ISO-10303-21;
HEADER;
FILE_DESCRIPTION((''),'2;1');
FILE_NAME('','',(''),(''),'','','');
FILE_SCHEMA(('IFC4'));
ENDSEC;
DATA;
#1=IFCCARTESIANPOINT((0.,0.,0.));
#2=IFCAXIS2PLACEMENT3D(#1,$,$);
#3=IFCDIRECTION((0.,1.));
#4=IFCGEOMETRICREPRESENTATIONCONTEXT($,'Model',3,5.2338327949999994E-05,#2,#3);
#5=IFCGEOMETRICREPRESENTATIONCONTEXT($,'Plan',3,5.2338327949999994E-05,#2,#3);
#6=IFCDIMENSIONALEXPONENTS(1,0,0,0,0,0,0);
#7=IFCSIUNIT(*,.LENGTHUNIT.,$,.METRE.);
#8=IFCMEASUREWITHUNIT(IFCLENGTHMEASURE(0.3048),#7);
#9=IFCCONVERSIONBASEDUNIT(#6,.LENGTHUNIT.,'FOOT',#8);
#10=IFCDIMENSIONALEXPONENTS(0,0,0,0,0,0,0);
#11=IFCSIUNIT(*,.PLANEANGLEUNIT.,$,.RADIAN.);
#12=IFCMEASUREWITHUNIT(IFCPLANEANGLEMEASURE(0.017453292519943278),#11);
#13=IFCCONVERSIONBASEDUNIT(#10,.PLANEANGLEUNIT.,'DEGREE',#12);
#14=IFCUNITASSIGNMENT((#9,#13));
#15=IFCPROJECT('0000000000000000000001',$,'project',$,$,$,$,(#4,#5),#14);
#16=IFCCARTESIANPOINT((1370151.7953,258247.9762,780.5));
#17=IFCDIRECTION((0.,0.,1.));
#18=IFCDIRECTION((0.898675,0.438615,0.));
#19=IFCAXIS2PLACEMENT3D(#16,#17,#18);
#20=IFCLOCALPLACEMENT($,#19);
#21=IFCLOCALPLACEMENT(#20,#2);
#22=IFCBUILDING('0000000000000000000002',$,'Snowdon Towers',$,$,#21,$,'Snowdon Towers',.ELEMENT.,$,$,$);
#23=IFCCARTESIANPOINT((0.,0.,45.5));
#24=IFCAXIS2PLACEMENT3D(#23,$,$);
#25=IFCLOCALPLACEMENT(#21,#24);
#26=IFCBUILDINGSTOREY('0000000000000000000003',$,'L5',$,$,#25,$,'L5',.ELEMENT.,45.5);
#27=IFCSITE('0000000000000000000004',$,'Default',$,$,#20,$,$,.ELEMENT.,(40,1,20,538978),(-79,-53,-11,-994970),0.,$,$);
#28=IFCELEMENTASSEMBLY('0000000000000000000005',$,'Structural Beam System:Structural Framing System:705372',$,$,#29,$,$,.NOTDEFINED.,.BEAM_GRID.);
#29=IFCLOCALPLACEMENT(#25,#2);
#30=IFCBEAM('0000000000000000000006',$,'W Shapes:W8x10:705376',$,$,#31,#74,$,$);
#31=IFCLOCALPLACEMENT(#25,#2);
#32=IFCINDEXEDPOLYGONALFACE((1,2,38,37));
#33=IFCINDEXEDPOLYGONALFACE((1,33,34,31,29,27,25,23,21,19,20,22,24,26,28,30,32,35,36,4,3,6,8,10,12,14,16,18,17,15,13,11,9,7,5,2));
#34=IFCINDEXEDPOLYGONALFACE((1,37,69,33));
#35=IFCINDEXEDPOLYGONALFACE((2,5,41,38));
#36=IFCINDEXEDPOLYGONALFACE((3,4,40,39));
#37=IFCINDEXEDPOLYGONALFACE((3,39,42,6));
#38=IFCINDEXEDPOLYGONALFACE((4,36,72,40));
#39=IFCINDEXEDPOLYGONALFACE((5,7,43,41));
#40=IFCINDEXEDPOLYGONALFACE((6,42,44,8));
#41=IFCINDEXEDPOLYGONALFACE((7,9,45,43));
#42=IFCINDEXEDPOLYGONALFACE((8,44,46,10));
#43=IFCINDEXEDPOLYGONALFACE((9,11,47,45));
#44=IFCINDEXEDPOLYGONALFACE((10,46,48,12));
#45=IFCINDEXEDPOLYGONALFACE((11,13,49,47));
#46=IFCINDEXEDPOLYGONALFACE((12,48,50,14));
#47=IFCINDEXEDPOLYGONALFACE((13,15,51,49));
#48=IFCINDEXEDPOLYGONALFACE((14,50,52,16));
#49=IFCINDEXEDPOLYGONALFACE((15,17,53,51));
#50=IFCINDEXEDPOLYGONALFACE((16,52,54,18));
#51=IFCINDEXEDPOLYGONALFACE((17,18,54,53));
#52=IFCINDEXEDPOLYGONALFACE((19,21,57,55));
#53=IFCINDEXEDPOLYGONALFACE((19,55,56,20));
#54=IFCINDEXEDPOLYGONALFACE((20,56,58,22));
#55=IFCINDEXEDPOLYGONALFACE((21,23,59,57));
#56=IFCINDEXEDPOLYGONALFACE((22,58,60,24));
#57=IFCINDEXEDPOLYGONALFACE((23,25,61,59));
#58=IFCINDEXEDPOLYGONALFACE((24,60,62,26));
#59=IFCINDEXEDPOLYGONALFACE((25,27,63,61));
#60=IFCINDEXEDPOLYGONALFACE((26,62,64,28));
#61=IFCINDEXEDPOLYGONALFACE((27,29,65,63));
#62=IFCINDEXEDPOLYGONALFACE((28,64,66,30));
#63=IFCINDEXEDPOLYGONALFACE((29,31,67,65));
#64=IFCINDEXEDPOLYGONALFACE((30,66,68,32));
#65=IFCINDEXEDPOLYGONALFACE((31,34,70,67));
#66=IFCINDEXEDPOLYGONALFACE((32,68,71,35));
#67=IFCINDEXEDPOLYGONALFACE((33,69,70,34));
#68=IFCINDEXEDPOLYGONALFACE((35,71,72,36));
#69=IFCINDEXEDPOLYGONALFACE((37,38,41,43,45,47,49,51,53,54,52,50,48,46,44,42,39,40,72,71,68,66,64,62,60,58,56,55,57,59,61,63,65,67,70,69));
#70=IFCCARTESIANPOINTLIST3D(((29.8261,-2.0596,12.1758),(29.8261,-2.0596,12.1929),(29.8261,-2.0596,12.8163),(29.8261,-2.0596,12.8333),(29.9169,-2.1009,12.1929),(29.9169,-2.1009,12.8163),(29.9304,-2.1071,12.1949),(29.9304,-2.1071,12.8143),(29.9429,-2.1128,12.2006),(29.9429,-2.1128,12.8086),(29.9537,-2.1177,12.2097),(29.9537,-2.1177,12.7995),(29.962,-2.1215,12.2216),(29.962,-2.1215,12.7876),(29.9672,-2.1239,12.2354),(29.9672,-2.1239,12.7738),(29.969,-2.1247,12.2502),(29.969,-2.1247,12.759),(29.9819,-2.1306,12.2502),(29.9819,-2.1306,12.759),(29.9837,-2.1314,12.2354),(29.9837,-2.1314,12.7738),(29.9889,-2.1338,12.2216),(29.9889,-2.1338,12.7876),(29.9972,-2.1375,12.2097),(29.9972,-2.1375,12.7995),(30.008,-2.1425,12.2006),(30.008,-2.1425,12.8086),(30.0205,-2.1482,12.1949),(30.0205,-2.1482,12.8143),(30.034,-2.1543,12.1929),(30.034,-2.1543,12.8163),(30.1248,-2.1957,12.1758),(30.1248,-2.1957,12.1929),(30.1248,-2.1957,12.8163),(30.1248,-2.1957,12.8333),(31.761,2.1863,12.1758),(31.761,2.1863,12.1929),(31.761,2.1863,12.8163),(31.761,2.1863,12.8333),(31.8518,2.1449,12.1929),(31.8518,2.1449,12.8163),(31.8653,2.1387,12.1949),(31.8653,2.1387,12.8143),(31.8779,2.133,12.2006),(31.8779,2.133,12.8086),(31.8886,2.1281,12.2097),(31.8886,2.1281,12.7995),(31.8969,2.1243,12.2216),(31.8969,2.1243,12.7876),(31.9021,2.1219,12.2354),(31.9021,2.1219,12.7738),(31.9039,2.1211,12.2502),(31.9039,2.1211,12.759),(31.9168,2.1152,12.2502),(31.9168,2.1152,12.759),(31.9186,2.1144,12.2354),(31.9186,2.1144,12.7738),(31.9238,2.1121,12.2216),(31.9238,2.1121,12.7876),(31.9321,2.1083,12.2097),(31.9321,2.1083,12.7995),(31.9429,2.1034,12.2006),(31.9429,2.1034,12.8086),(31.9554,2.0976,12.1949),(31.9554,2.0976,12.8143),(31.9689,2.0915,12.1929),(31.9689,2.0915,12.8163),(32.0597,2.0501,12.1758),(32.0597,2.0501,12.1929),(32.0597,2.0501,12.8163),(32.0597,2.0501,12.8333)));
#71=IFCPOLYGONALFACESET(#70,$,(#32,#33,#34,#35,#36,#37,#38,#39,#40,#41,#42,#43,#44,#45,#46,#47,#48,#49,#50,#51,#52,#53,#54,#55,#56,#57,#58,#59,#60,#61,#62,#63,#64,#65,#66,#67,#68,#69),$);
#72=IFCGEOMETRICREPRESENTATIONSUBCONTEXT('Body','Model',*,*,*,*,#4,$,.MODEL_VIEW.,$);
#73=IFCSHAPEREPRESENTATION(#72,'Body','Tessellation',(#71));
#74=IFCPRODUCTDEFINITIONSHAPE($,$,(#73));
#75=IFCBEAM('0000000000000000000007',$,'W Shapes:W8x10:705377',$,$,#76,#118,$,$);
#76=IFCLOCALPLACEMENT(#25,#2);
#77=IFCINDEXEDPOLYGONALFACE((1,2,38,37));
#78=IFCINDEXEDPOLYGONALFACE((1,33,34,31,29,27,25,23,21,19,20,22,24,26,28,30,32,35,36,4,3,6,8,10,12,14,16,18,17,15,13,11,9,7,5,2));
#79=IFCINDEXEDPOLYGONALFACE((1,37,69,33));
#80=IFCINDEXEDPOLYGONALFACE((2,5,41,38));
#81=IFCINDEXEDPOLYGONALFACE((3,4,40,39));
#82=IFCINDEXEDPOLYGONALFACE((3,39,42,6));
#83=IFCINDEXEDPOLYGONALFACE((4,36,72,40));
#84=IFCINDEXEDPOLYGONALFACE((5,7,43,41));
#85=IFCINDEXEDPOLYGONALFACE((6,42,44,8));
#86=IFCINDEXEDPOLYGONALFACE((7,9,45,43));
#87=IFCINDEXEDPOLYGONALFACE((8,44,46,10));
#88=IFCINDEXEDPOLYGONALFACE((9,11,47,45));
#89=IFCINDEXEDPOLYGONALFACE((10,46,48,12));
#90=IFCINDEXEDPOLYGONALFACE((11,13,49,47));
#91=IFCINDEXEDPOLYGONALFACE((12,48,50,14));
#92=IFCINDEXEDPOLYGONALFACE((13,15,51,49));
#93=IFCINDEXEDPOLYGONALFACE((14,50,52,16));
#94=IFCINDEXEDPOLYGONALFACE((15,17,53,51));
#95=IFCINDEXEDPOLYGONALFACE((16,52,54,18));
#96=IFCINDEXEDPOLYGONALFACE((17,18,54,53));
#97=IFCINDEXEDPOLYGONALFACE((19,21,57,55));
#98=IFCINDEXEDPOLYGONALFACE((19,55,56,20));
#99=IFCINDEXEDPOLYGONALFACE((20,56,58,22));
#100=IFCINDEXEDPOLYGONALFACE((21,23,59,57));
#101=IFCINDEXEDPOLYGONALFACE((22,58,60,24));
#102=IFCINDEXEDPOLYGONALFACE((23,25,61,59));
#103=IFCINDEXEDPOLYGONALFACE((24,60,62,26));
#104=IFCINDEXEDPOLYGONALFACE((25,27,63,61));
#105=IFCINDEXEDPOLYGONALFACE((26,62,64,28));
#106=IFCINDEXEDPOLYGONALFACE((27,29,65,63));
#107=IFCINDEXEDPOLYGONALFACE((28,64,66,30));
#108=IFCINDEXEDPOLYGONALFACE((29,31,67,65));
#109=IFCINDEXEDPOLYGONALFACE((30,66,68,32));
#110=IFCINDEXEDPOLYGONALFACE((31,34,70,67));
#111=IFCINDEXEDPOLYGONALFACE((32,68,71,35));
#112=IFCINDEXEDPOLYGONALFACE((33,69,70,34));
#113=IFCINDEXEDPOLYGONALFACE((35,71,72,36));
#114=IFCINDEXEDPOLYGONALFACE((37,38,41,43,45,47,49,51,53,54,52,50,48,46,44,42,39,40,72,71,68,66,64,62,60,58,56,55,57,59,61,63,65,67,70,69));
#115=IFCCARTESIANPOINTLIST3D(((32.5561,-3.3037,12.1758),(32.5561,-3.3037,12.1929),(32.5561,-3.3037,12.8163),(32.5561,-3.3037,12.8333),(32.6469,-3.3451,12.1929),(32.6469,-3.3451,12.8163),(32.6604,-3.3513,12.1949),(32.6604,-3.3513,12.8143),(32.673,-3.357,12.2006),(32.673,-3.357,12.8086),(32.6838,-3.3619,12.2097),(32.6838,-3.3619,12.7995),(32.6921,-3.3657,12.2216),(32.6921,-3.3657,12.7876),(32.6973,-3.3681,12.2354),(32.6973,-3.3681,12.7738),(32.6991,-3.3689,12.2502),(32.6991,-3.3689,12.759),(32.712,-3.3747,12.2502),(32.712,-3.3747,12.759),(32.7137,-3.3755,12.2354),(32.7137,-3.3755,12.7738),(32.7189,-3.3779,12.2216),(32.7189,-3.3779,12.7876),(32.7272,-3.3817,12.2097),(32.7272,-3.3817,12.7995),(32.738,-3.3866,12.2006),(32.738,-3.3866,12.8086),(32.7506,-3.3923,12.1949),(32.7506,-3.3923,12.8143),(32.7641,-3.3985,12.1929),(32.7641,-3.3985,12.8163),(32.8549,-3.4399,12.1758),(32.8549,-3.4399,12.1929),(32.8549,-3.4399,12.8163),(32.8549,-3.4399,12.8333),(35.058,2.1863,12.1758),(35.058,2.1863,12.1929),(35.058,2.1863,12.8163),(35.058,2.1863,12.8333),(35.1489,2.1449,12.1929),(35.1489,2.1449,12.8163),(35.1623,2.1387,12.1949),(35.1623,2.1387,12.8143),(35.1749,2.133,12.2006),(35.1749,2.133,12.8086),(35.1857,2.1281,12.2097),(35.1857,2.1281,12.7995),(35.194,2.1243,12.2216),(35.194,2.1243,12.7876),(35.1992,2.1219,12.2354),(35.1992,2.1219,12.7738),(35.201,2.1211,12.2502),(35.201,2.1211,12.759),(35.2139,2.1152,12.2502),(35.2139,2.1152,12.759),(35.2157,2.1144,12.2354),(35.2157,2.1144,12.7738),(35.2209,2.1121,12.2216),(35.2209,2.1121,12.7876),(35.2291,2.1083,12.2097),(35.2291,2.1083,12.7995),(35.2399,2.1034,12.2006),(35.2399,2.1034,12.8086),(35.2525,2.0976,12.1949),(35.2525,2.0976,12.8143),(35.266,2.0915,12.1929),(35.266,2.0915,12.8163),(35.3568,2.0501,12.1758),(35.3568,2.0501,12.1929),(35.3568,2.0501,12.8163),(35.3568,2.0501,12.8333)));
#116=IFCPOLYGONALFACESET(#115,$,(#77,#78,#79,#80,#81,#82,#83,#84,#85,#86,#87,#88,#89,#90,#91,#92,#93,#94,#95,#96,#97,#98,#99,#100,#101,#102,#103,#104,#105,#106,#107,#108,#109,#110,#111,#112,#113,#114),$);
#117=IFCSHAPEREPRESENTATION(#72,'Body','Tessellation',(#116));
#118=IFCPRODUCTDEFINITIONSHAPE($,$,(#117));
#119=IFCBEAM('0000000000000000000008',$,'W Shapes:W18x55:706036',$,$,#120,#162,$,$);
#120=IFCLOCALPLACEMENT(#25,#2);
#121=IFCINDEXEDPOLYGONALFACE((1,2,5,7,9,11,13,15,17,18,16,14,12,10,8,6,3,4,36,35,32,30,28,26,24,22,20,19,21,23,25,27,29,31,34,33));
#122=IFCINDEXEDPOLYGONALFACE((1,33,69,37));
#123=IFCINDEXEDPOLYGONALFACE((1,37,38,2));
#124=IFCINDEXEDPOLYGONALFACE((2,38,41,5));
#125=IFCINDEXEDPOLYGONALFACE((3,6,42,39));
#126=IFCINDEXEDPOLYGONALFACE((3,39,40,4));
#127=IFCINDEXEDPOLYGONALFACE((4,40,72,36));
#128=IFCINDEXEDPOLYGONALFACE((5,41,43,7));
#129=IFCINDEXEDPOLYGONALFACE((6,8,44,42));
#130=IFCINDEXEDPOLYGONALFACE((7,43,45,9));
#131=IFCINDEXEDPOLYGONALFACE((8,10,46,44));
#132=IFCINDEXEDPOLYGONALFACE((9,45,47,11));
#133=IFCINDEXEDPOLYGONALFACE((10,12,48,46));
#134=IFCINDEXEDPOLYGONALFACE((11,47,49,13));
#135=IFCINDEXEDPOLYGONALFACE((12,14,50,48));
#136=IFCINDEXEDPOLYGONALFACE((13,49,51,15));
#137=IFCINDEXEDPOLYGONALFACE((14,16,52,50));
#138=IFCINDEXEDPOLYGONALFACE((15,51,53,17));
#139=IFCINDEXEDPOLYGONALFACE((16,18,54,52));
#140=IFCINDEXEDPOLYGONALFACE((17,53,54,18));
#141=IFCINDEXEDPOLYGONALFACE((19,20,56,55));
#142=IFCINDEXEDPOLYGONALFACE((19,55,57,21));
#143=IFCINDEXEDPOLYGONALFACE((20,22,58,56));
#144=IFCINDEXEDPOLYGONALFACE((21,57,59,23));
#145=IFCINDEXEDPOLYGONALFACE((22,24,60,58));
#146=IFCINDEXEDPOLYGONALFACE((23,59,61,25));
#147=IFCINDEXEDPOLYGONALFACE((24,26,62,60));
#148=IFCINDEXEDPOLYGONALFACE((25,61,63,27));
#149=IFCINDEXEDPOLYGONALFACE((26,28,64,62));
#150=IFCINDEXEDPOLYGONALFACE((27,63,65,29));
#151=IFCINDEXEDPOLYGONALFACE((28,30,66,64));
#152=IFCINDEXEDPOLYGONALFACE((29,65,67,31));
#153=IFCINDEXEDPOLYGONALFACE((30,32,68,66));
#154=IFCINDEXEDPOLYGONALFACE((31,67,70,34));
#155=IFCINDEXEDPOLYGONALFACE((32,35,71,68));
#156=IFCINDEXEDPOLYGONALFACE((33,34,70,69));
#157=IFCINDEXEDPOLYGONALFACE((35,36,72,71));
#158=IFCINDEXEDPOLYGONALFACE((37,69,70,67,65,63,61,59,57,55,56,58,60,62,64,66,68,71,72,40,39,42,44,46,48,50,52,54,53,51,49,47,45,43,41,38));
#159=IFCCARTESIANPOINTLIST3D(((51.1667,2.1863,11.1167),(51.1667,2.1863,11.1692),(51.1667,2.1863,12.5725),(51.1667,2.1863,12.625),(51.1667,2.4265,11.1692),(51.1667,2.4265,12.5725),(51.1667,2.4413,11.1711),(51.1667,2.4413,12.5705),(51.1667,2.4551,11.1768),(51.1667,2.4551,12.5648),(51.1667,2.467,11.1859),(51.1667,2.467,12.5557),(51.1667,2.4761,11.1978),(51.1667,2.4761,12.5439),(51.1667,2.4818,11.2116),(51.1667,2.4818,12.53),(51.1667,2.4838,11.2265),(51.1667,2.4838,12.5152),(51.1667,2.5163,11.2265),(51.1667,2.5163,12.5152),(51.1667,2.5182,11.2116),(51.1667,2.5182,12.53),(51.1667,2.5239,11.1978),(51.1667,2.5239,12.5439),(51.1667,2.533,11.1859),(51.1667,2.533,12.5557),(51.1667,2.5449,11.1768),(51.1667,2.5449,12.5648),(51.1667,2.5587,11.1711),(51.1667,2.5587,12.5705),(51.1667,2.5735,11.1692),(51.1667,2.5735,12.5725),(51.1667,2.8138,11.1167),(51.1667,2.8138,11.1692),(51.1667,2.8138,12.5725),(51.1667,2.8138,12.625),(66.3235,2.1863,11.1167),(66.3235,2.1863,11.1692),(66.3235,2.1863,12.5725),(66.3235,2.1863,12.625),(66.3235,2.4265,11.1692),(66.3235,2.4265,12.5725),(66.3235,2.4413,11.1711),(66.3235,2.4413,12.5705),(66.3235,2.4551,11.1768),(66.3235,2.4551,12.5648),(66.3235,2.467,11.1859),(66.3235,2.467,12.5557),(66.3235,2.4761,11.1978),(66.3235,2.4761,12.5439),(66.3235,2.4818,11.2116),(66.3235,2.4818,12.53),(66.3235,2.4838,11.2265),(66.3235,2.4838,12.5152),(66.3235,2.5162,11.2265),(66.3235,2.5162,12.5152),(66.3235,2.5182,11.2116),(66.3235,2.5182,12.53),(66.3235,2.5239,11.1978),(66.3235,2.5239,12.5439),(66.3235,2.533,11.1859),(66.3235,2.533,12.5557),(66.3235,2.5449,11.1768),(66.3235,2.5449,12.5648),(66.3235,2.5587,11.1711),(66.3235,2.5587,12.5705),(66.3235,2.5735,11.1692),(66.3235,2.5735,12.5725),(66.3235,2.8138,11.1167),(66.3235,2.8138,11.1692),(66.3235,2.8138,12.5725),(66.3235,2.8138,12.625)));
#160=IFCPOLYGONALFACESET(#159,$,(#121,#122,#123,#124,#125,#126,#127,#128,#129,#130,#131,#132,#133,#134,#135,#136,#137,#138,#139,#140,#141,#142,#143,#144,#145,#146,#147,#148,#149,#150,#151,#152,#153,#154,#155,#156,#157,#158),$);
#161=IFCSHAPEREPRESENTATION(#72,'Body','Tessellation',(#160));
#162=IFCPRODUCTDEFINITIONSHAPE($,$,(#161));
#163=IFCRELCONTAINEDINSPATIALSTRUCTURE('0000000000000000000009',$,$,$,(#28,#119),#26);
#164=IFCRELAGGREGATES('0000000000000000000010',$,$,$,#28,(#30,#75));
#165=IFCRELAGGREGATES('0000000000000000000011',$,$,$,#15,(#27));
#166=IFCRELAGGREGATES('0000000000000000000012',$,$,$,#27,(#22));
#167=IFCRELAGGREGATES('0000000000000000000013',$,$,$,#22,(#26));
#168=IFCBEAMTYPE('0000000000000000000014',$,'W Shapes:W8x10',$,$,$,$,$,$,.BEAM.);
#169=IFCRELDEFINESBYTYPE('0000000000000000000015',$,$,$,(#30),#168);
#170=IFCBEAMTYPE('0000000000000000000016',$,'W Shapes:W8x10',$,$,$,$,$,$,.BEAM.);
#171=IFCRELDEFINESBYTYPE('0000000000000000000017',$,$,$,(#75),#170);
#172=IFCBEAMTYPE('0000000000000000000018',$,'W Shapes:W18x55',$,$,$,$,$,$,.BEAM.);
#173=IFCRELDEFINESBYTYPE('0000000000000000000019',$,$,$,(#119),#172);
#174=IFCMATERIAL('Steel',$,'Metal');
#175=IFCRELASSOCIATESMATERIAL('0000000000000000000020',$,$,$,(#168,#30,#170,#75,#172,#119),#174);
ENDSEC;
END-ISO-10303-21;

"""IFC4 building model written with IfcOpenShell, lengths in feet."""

from ifc_helpers import new_model, entity, si_unit, converted_unit, direction, frame, origin, place, context, subcontext, project, spatial, line, arc, indexed_curve, outline, extrude, source, transform, mapped, material, type_object, type_shapes, element, aggregate, save


model = new_model("IFC4")

# Units and contexts
model_context = context("Model", 3, precision=5.2338327949999994e-05, world=origin(), true_north=direction((0.0, 1.0)))
plan_context = context("Plan", 3, precision=5.2338327949999994e-05, world=origin(), true_north=direction((0.0, 1.0)))
body_context = subcontext(model_context, "Body", "Model", "MODEL_VIEW")
ifc_project = project(units=[converted_unit("LENGTHUNIT", "FOOT", entity("IfcLengthMeasure", 0.3048), si_unit("LENGTHUNIT", "METRE"), dimensions=[1, 0, 0, 0, 0, 0, 0]), converted_unit("PLANEANGLEUNIT", "DEGREE", entity("IfcPlaneAngleMeasure", 0.017453292519943278), si_unit("PLANEANGLEUNIT", "RADIAN"), dimensions=[0, 0, 0, 0, 0, 0, 0])], contexts=[model_context, plan_context])

# Site, building, storey
site_placement = place(None, frame((1370151.7953, 258247.9762, 780.5), z_axis=(0.0, 0.0, 1.0), x_axis=(0.898675, 0.438615, 0.0)))
site = spatial("IfcSite", under=ifc_project, at=site_placement, Name="Default", CompositionType="ELEMENT", RefLatitude=(40, 1, 20, 538978), RefLongitude=(-79, -53, -11, -994970), RefElevation=0.0)
building_placement = place(site_placement, origin())
building = spatial("IfcBuilding", under=site, at=building_placement, Name="Snowdon Towers", LongName="Snowdon Towers", CompositionType="ELEMENT")
storey_placement = place(building_placement, frame((0.0, 0.0, 45.5)))
storey = spatial("IfcBuildingStorey", under=building, at=storey_placement, Name="L5", LongName="L5", CompositionType="ELEMENT", Elevation=45.5)

# Shared definitions
ifc_material = material(Name="Steel", Category="Metal")

# Element assembly, beams
assembly_1_placement = place(storey_placement, origin())
assembly_1 = element("IfcElementAssembly", 1, at=assembly_1_placement, inside=storey, Name="Structural Beam System:Structural Framing System:705372", AssemblyPlace="NOTDEFINED", PredefinedType="BEAM_GRID")
beam_type_1 = type_object("IfcBeamType", Name="W Shapes:W8x10", PredefinedType="BEAM", material=ifc_material)
shared_shape_1 = source(origin(), body_context, "Body", "SweptSolid", [
    extrude(outline(indexed_curve([(-0.3287, -0.1642), (-0.3117, -0.1642), (-0.3117, -0.0644), (-0.2949, -0.0239), (-0.2544, -0.0071), (0.2544, -0.0071), (0.2949, -0.0239), (0.3117, -0.0644), (0.3117, -0.1642), (0.3288, -0.1642), (0.3288, 0.1642), (0.3117, 0.1642), (0.3117, 0.0644), (0.2949, 0.0239), (0.2544, 0.0071), (-0.2544, 0.0071), (-0.2949, 0.0239), (-0.3117, 0.0644), (-0.3117, 0.1642), (-0.3287, 0.1642)], segments=[line(1, 2, 3), arc(3, 4, 5), line(5, 6), arc(6, 7, 8), line(8, 9, 10, 11, 12, 13), arc(13, 14, 15), line(15, 16), arc(16, 17, 18), line(18, 19, 20, 1)], self_intersect=False)), frame((-2.4076, 0.0, 0.0), z_axis=(1.0, 0.0, 0.0), x_axis=(0.0, 0.0, -1.0)), (0.0, 0.0, 1.0), 4.6659),
])
type_shapes(beam_type_1, [shared_shape_1])
beam_1_placement = place(assembly_1_placement, frame((30.9738, 0.0631, 12.5046), z_axis=(0.0, 0.0, 1.0), x_axis=(0.414693, 0.909961, 0.0)))
beam_1 = element("IfcBeam", 2, at=beam_1_placement, type_object=beam_type_1, material=ifc_material, Name="W Shapes:W8x10:705376", context=body_context, shape_type="MappedRepresentation", body=[
    mapped(shared_shape_1, transform((0.0, 0.0, 0.0), scale=1.0)),
])
beam_type_2 = type_object("IfcBeamType", Name="W Shapes:W8x10", PredefinedType="BEAM", material=ifc_material)
shared_shape_2 = source(origin(), body_context, "Body", "SweptSolid", [
    extrude(outline(indexed_curve([(-0.3287, -0.1642), (-0.3117, -0.1642), (-0.3117, -0.0644), (-0.2949, -0.0239), (-0.2544, -0.0071), (0.2544, -0.0071), (0.2949, -0.0239), (0.3117, -0.0644), (0.3117, -0.1642), (0.3288, -0.1642), (0.3288, 0.1642), (0.3117, 0.1642), (0.3117, 0.0644), (0.2949, 0.0239), (0.2544, 0.0071), (-0.2544, 0.0071), (-0.2949, 0.0239), (-0.3117, 0.0644), (-0.3117, 0.1642), (-0.3287, 0.1642)], segments=[line(1, 2, 3), arc(3, 4, 5), line(5, 6), arc(6, 7, 8), line(8, 9, 10, 11, 12, 13), arc(13, 14, 15), line(15, 16), arc(16, 17, 18), line(18, 19, 20, 1)], self_intersect=False)), frame((-3.0912, 0.0, 0.0), z_axis=(1.0, 0.0, 0.0), x_axis=(0.0, 0.0, -1.0)), (0.0, 0.0, 1.0), 6.0332),
])
type_shapes(beam_type_2, [shared_shape_2])
beam_2_placement = place(assembly_1_placement, frame((33.9874, -0.5589, 12.5046), z_axis=(0.0, 0.0, 1.0), x_axis=(0.414693, 0.909961, 0.0)))
beam_2 = element("IfcBeam", 3, at=beam_2_placement, type_object=beam_type_2, material=ifc_material, Name="W Shapes:W8x10:705377", context=body_context, shape_type="MappedRepresentation", body=[
    mapped(shared_shape_2, transform((0.0, 0.0, 0.0), scale=1.0)),
])

# Beam
beam_type_3 = type_object("IfcBeamType", Name="W Shapes:W18x55", PredefinedType="BEAM", material=ifc_material)
shared_shape_3 = source(origin(), body_context, "Body", "SweptSolid", [
    extrude(outline(indexed_curve([(-0.7542, -0.3138), (-0.7017, -0.3138), (-0.7017, -0.0735), (-0.6849, -0.033), (-0.6444, -0.0162), (0.6444, -0.0162), (0.6849, -0.033), (0.7017, -0.0735), (0.7017, -0.3138), (0.7542, -0.3138), (0.7542, 0.3138), (0.7017, 0.3138), (0.7017, 0.0735), (0.6849, 0.033), (0.6444, 0.0163), (-0.6444, 0.0163), (-0.6849, 0.033), (-0.7017, 0.0735), (-0.7017, 0.3137), (-0.7542, 0.3137)], segments=[line(1, 2, 3), arc(3, 4, 5), line(5, 6), arc(6, 7, 8), line(8, 9, 10, 11, 12, 13), arc(13, 14, 15), line(15, 16), arc(16, 17, 18), line(18, 19, 20, 1)], self_intersect=False)), frame((-7.2596, 0.0, 0.0), z_axis=(1.0, 0.0, 0.0), x_axis=(0.0, 0.0, -1.0)), (0.0, 0.0, 1.0), 15.1568),
])
type_shapes(beam_type_3, [shared_shape_3])
beam_3_placement = place(storey_placement, frame((59.0638, 2.5, 11.8708), z_axis=(0.0, 0.0, 1.0), x_axis=(-1.0, 0.0, 0.0)))
element("IfcBeam", 4, at=beam_3_placement, inside=storey, type_object=beam_type_3, material=ifc_material, Name="W Shapes:W18x55:706036", context=body_context, shape_type="MappedRepresentation", body=[
    mapped(shared_shape_3, transform((0.0, 0.0, 0.0), scale=1.0)),
])

aggregate(assembly_1, [beam_1, beam_2])

save(model, "model.ifc")
